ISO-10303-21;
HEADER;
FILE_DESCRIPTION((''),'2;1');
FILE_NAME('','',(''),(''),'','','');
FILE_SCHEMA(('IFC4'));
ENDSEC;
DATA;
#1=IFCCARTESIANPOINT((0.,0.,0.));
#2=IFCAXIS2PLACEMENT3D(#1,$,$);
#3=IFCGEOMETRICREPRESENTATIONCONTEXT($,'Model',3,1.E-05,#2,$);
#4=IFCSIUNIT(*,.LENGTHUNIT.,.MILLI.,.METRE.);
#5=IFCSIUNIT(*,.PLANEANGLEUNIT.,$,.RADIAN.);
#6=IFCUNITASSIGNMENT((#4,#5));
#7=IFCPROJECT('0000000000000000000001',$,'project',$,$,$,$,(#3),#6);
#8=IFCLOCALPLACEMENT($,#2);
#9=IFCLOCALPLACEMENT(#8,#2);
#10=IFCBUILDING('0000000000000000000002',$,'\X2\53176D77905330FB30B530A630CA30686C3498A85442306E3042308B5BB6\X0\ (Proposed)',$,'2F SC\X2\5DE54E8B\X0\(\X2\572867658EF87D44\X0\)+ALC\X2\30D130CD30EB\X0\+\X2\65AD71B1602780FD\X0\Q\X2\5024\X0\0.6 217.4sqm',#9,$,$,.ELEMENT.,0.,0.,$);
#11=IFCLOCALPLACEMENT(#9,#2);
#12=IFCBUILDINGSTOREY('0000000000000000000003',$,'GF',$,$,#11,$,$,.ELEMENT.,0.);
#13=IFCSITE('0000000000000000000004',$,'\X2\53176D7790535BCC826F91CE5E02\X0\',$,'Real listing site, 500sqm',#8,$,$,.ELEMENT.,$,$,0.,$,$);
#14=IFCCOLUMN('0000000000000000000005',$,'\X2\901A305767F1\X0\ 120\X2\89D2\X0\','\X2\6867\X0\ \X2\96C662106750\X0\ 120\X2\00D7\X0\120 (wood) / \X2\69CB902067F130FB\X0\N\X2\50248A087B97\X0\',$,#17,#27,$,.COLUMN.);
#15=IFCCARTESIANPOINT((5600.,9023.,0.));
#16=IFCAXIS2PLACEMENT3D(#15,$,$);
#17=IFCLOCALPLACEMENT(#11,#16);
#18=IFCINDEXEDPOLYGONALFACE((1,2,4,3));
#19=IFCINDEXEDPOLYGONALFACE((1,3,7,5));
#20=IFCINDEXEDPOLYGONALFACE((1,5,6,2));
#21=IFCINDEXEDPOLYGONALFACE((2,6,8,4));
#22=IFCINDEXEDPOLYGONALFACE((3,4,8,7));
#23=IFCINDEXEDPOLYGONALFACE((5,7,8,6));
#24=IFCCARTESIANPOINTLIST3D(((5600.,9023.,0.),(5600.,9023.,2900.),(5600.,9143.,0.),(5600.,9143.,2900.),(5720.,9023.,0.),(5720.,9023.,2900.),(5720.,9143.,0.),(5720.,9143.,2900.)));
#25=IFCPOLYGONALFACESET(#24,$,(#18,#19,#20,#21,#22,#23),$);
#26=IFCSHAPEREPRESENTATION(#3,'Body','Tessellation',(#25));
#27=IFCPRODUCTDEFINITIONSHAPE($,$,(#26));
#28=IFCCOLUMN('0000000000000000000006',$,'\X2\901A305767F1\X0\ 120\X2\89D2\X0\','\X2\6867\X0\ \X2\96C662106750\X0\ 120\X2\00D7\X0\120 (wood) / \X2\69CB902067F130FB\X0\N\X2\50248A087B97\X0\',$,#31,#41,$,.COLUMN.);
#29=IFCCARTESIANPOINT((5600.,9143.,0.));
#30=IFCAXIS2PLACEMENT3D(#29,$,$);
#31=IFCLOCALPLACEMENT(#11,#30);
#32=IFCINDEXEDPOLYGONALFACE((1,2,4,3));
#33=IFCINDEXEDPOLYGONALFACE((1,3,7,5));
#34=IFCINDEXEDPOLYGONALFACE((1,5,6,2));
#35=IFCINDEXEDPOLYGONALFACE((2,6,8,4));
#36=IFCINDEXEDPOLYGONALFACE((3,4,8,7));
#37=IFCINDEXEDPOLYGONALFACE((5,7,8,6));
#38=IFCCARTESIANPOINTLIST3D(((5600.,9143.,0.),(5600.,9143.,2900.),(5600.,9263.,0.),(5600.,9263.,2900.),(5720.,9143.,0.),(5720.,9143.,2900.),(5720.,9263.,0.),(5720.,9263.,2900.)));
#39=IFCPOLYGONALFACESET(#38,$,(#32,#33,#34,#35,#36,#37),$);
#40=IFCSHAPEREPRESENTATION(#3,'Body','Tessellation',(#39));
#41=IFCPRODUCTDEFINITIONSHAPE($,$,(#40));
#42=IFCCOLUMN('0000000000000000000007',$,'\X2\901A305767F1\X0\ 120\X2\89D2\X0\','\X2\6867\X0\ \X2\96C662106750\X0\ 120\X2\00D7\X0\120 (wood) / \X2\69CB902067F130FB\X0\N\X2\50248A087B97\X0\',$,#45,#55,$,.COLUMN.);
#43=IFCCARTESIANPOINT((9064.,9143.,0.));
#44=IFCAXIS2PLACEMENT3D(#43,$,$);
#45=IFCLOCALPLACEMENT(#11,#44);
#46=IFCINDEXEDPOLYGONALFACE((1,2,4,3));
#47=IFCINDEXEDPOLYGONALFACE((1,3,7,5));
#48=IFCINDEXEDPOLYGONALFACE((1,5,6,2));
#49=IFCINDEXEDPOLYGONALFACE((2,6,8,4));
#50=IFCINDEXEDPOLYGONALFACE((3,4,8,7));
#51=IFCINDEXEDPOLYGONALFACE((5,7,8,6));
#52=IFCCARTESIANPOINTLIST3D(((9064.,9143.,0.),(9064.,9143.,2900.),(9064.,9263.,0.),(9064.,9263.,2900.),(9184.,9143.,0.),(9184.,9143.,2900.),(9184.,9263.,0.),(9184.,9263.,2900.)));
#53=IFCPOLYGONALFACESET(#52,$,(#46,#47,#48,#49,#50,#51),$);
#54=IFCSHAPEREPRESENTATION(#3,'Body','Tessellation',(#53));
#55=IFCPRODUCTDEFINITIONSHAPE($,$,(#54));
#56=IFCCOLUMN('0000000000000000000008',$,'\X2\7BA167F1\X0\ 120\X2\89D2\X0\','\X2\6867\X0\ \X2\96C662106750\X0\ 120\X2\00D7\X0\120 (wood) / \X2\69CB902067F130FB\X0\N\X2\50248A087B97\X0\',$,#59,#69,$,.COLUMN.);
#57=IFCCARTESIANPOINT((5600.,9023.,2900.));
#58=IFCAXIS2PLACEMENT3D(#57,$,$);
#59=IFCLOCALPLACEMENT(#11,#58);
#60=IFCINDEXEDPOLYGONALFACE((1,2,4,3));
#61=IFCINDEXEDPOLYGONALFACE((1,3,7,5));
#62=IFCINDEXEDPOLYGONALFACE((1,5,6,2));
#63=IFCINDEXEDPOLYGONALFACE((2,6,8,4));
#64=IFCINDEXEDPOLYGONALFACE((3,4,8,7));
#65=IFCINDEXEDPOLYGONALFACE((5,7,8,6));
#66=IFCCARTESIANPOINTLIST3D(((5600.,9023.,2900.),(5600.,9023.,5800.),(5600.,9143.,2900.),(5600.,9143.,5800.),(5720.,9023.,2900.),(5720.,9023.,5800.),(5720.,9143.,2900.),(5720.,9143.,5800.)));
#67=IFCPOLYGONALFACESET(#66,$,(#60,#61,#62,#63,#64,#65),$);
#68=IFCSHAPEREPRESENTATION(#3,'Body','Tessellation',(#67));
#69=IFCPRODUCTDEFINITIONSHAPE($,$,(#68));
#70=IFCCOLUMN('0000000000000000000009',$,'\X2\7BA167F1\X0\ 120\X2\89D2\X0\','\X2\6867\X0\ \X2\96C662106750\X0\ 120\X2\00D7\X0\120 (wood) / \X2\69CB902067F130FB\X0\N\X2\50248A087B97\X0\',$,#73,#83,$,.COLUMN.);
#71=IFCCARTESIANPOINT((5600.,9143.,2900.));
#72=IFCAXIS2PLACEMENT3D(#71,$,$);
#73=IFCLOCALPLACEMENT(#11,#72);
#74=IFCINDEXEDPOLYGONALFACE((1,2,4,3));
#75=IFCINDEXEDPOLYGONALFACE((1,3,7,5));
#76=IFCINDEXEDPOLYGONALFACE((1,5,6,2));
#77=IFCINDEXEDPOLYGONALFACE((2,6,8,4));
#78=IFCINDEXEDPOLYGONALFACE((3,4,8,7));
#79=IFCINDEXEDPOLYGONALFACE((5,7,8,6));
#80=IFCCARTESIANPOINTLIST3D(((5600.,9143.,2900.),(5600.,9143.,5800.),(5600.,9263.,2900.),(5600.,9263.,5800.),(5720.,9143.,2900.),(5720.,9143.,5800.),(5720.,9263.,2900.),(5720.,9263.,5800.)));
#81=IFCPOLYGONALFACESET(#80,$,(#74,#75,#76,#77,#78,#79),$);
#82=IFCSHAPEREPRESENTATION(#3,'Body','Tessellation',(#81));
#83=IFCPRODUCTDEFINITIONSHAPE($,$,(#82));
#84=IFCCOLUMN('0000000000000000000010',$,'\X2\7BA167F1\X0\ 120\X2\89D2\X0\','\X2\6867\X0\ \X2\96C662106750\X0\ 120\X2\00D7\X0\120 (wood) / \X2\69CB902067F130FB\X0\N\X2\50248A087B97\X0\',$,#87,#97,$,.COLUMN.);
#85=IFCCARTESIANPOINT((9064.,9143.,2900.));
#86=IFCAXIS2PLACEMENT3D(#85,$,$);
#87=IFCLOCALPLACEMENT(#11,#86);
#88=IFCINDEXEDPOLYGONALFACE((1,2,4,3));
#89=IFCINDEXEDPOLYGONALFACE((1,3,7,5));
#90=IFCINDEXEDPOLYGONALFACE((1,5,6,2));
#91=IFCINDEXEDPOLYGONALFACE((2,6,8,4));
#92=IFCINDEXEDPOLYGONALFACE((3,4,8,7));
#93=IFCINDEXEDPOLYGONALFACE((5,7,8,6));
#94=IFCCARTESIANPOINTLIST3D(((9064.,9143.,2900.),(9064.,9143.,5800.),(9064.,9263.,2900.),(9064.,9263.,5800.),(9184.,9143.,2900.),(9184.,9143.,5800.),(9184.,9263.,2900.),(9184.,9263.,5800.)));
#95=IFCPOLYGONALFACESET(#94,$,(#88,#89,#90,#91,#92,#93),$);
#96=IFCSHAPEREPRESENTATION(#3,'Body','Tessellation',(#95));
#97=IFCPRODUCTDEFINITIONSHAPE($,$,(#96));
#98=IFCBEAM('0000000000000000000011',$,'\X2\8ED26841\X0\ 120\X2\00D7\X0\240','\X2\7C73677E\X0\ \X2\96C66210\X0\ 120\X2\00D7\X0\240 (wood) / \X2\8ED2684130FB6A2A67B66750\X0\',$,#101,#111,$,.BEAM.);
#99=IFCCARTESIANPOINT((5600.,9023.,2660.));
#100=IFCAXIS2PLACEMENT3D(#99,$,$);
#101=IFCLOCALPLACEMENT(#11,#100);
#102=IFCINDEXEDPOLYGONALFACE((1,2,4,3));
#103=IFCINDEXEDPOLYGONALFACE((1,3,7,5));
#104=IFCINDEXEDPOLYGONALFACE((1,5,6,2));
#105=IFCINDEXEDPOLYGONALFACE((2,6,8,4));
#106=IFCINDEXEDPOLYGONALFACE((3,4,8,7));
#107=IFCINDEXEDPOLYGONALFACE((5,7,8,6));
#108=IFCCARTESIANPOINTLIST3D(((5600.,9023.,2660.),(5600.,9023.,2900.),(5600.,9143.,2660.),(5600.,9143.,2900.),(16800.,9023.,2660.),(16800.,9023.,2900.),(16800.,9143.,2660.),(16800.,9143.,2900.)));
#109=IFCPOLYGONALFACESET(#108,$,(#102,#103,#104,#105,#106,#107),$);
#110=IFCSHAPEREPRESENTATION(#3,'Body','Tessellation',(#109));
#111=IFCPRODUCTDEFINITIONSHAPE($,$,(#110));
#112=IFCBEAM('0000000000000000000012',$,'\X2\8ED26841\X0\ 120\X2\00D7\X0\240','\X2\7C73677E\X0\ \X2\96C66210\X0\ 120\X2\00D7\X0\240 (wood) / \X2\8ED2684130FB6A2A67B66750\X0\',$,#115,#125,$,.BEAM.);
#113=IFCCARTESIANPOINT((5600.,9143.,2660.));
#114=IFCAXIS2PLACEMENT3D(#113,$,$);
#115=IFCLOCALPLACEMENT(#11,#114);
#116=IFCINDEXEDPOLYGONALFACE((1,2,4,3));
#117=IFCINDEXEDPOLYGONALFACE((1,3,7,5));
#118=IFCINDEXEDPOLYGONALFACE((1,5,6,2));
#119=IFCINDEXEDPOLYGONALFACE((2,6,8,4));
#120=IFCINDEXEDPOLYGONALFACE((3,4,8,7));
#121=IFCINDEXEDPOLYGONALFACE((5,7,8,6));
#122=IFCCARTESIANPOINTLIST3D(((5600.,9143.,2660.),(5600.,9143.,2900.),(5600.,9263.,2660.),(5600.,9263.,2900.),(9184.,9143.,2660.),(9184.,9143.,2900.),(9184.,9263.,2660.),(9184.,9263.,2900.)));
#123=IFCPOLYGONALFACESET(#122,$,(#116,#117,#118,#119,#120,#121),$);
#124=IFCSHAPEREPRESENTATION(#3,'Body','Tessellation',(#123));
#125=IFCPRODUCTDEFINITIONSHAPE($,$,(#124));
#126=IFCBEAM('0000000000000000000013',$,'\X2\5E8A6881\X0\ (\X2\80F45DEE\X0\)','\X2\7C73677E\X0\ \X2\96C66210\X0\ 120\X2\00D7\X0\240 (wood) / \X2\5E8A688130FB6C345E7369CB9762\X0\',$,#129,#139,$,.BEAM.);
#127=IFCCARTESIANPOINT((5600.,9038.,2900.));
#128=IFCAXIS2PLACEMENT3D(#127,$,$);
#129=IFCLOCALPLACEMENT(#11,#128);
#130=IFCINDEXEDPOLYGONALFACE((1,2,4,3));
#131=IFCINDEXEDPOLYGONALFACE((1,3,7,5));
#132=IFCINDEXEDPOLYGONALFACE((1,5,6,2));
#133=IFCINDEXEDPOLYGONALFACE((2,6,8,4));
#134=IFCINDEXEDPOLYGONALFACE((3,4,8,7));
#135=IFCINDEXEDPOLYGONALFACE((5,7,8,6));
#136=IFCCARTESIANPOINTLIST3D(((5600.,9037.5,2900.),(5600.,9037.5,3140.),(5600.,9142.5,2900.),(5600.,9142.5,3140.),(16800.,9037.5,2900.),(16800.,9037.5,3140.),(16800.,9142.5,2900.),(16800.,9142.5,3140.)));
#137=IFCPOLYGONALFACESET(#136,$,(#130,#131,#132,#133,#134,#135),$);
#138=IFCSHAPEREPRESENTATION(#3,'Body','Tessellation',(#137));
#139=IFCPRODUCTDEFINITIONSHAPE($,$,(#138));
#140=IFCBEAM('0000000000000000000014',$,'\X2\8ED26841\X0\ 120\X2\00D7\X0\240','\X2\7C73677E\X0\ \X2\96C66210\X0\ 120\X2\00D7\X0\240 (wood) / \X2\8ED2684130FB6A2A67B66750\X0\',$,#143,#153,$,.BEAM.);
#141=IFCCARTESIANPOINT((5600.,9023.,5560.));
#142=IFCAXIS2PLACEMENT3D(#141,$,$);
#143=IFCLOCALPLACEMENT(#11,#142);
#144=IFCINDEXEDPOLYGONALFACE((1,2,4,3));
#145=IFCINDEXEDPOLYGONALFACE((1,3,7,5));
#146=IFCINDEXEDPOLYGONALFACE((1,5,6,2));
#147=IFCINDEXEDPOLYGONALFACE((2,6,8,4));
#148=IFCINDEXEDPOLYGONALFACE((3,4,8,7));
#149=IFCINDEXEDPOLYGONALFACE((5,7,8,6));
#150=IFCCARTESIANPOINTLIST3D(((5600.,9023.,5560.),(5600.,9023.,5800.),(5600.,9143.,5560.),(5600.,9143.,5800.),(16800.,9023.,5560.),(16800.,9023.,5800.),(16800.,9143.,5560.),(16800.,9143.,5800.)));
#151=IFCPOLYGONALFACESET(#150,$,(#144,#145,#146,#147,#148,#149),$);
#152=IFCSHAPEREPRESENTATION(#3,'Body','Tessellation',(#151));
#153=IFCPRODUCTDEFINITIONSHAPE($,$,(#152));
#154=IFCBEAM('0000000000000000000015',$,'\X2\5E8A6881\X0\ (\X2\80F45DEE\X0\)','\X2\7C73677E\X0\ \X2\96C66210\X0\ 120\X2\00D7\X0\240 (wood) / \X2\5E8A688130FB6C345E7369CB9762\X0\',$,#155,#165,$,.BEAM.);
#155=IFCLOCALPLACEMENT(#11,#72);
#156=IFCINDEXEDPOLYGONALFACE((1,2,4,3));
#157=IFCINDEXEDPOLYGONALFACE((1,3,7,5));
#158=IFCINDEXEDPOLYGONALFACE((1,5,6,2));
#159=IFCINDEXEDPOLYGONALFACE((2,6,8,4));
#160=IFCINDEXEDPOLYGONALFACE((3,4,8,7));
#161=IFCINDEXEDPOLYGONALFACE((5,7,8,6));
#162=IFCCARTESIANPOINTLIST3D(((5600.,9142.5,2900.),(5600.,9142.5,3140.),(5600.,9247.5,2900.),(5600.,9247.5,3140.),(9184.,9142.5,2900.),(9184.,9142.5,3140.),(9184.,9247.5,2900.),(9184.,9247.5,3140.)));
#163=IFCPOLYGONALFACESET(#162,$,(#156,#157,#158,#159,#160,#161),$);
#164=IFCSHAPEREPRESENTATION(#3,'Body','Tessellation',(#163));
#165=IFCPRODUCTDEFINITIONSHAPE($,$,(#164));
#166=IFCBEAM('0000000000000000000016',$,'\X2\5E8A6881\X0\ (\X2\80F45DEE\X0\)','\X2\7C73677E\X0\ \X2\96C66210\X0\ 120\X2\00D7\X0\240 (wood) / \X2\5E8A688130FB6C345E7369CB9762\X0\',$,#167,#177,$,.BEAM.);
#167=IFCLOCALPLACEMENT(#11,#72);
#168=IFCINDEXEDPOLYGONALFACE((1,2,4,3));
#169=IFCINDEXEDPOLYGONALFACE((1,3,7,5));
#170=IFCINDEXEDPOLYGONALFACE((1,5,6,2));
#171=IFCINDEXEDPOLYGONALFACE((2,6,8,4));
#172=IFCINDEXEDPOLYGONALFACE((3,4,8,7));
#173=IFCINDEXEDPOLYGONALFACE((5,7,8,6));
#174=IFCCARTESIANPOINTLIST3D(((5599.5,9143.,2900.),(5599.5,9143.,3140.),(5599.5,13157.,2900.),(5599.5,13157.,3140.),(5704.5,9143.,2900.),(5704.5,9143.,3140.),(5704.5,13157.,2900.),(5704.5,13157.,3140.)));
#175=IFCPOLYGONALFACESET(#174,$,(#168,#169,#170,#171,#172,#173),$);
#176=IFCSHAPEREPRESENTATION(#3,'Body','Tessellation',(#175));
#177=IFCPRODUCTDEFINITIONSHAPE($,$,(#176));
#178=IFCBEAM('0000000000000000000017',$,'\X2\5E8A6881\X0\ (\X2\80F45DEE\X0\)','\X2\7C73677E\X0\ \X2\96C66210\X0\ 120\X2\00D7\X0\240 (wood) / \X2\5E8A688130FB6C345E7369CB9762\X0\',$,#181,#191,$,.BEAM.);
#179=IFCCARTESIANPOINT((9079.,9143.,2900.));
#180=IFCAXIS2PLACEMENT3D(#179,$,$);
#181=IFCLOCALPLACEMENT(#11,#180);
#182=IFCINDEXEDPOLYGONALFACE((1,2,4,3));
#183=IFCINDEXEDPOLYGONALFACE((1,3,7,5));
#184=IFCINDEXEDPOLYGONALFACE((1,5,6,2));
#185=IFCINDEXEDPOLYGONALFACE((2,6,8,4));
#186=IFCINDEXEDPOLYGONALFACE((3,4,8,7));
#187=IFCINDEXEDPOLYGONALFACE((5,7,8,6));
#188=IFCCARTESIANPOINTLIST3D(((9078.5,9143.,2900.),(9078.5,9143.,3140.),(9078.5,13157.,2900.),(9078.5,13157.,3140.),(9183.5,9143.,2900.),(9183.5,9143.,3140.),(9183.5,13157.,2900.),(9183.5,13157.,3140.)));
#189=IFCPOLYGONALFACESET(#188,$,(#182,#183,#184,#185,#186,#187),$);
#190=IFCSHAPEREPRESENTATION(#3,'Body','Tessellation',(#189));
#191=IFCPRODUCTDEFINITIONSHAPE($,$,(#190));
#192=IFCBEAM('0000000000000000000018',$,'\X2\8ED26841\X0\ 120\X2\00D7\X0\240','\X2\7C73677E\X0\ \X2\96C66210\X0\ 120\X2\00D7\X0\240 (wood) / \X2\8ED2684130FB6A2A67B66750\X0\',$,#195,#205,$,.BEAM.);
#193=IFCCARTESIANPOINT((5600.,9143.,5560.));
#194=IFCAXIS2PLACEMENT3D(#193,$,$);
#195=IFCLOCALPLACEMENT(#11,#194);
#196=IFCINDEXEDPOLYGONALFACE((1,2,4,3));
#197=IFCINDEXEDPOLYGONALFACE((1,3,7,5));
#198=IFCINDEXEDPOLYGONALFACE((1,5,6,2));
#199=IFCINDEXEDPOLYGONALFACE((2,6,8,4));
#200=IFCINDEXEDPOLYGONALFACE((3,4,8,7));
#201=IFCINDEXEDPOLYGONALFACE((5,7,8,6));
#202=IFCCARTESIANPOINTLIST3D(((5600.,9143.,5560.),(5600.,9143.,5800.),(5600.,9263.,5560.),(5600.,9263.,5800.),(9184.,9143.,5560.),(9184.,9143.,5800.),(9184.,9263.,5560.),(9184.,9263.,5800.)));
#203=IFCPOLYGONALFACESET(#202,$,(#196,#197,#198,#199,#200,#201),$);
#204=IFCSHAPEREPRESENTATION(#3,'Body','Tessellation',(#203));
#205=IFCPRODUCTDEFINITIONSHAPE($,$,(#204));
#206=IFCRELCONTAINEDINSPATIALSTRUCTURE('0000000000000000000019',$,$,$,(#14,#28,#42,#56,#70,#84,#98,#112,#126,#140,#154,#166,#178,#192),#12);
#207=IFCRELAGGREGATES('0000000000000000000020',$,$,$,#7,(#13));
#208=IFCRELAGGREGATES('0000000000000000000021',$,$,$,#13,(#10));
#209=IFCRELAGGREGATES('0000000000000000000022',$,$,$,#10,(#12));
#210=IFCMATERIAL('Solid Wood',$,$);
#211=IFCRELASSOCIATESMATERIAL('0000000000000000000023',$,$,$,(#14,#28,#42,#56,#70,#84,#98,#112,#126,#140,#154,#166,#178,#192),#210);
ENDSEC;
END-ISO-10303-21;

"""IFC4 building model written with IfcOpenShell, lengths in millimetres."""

from ifc_helpers import new_model, si_unit, frame, frame_2d, origin, place, context, project, spatial, rectangle, extrude, material, element, save


model = new_model("IFC4")

# Units and contexts
model_context = context("Model", 3, precision=1e-05, world=origin())
ifc_project = project(units=[si_unit("LENGTHUNIT", "METRE", prefix="MILLI"), si_unit("PLANEANGLEUNIT", "RADIAN")], contexts=[model_context])

# Site, building, storey
site_placement = place(None, origin())
site = spatial("IfcSite", under=ifc_project, at=site_placement, Name="北海道富良野市", ObjectType="Real listing site, 500sqm", CompositionType="ELEMENT", RefElevation=0.0)
building_placement = place(site_placement, origin())
building = spatial("IfcBuilding", under=site, at=building_placement, Name="北海道・サウナと水風呂のある家 (Proposed)", ObjectType="2F SC工事(在来軸組)+ALCパネル+断熱性能Q値0.6 217.4sqm", CompositionType="ELEMENT", ElevationOfRefHeight=0.0, ElevationOfTerrain=0.0)
storey_placement = place(building_placement, origin())
storey = spatial("IfcBuildingStorey", under=building, at=storey_placement, Name="GF", CompositionType="ELEMENT", Elevation=0.0)

# Columns
ifc_material_1 = material(Name="Solid Wood")
column_1_placement = place(storey_placement, frame((5600.0, 9023.0, 0.0)))
element("IfcColumn", 1, at=column_1_placement, inside=storey, material=ifc_material_1, Name="通し柱 120角", Description="桧 集成材 120×120 (wood) / 構造柱・N値計算", PredefinedType="COLUMN", context=model_context, shape_type="SweptSolid", body=[
    extrude(rectangle(XDim=120.0, YDim=120.0, at=frame_2d((60.0, 60.0))), frame((5600.0, 9023.0, 0.0)), (0.0, 0.0, 1.0), 2900.0),
])
column_2_placement = place(storey_placement, frame((5600.0, 9143.0, 0.0)))
element("IfcColumn", 2, at=column_2_placement, inside=storey, material=ifc_material_1, Name="通し柱 120角", Description="桧 集成材 120×120 (wood) / 構造柱・N値計算", PredefinedType="COLUMN", context=model_context, shape_type="SweptSolid", body=[
    extrude(rectangle(XDim=120.0, YDim=120.0, at=frame_2d((60.0, 60.0))), frame((5600.0, 9143.0, 0.0)), (0.0, 0.0, 1.0), 2900.0),
])
column_3_placement = place(storey_placement, frame((9064.0, 9143.0, 0.0)))
element("IfcColumn", 3, at=column_3_placement, inside=storey, material=ifc_material_1, Name="通し柱 120角", Description="桧 集成材 120×120 (wood) / 構造柱・N値計算", PredefinedType="COLUMN", context=model_context, shape_type="SweptSolid", body=[
    extrude(rectangle(XDim=120.0, YDim=120.0, at=frame_2d((60.0, 60.0))), frame((9064.0, 9143.0, 0.0)), (0.0, 0.0, 1.0), 2900.0),
])
column_4_placement = place(storey_placement, frame((5600.0, 9023.0, 2900.0)))
element("IfcColumn", 4, at=column_4_placement, inside=storey, material=ifc_material_1, Name="管柱 120角", Description="桧 集成材 120×120 (wood) / 構造柱・N値計算", PredefinedType="COLUMN", context=model_context, shape_type="SweptSolid", body=[
    extrude(rectangle(XDim=120.0, YDim=120.0, at=frame_2d((60.0, 60.0))), frame((5600.0, 9023.0, 2900.0)), (0.0, 0.0, 1.0), 2900.0),
])
column_5_placement = place(storey_placement, frame((5600.0, 9143.0, 2900.0)))
element("IfcColumn", 5, at=column_5_placement, inside=storey, material=ifc_material_1, Name="管柱 120角", Description="桧 集成材 120×120 (wood) / 構造柱・N値計算", PredefinedType="COLUMN", context=model_context, shape_type="SweptSolid", body=[
    extrude(rectangle(XDim=120.0, YDim=120.0, at=frame_2d((60.0, 60.0))), frame((5600.0, 9143.0, 2900.0)), (0.0, 0.0, 1.0), 2900.0),
])
column_6_placement = place(storey_placement, frame((9064.0, 9143.0, 2900.0)))
element("IfcColumn", 6, at=column_6_placement, inside=storey, material=ifc_material_1, Name="管柱 120角", Description="桧 集成材 120×120 (wood) / 構造柱・N値計算", PredefinedType="COLUMN", context=model_context, shape_type="SweptSolid", body=[
    extrude(rectangle(XDim=120.0, YDim=120.0, at=frame_2d((60.0, 60.0))), frame((9064.0, 9143.0, 2900.0)), (0.0, 0.0, 1.0), 2900.0),
])

# Beams
beam_1_placement = place(storey_placement, frame((5600.0, 9023.0, 2660.0)))
element("IfcBeam", 7, at=beam_1_placement, inside=storey, material=ifc_material_1, Name="軒桁 120×240", Description="米松 集成 120×240 (wood) / 軒桁・横架材", PredefinedType="BEAM", context=model_context, shape_type="SweptSolid", body=[
    extrude(rectangle(XDim=11200.0, YDim=120.0, at=frame_2d((5600.0, 60.0))), frame((5600.0, 9023.0, 2660.0)), (0.0, 0.0, 1.0), 240.0),
])
beam_2_placement = place(storey_placement, frame((5600.0, 9143.0, 2660.0)))
element("IfcBeam", 8, at=beam_2_placement, inside=storey, material=ifc_material_1, Name="軒桁 120×240", Description="米松 集成 120×240 (wood) / 軒桁・横架材", PredefinedType="BEAM", context=model_context, shape_type="SweptSolid", body=[
    extrude(rectangle(XDim=3584.0, YDim=120.0, at=frame_2d((1792.0, 60.0))), frame((5600.0, 9143.0, 2660.0)), (0.0, 0.0, 1.0), 240.0),
])
beam_3_placement = place(storey_placement, frame((5600.0, 9038.0, 2900.0)))
element("IfcBeam", 9, at=beam_3_placement, inside=storey, material=ifc_material_1, Name="床梁 (胴差)", Description="米松 集成 120×240 (wood) / 床梁・水平構面", PredefinedType="BEAM", context=model_context, shape_type="SweptSolid", body=[
    extrude(rectangle(XDim=11200.0, YDim=105.0, at=frame_2d((5600.0, 52.0))), frame((5600.0, 9038.0, 2900.0)), (0.0, 0.0, 1.0), 240.0),
])
beam_4_placement = place(storey_placement, frame((5600.0, 9023.0, 5560.0)))
element("IfcBeam", 10, at=beam_4_placement, inside=storey, material=ifc_material_1, Name="軒桁 120×240", Description="米松 集成 120×240 (wood) / 軒桁・横架材", PredefinedType="BEAM", context=model_context, shape_type="SweptSolid", body=[
    extrude(rectangle(XDim=11200.0, YDim=120.0, at=frame_2d((5600.0, 60.0))), frame((5600.0, 9023.0, 5560.0)), (0.0, 0.0, 1.0), 240.0),
])
beam_5_placement = place(storey_placement, frame((5600.0, 9143.0, 2900.0)))
element("IfcBeam", 11, at=beam_5_placement, inside=storey, material=ifc_material_1, Name="床梁 (胴差)", Description="米松 集成 120×240 (wood) / 床梁・水平構面", PredefinedType="BEAM", context=model_context, shape_type="SweptSolid", body=[
    extrude(rectangle(XDim=3584.0, YDim=105.0, at=frame_2d((1792.0, 52.0))), frame((5600.0, 9143.0, 2900.0)), (0.0, 0.0, 1.0), 240.0),
])
beam_6_placement = place(storey_placement, frame((5600.0, 9143.0, 2900.0)))
element("IfcBeam", 12, at=beam_6_placement, inside=storey, material=ifc_material_1, Name="床梁 (胴差)", Description="米松 集成 120×240 (wood) / 床梁・水平構面", PredefinedType="BEAM", context=model_context, shape_type="SweptSolid", body=[
    extrude(rectangle(XDim=105.0, YDim=4014.0, at=frame_2d((52.0, 2007.0))), frame((5600.0, 9143.0, 2900.0)), (0.0, 0.0, 1.0), 240.0),
])
beam_7_placement = place(storey_placement, frame((9079.0, 9143.0, 2900.0)))
element("IfcBeam", 13, at=beam_7_placement, inside=storey, material=ifc_material_1, Name="床梁 (胴差)", Description="米松 集成 120×240 (wood) / 床梁・水平構面", PredefinedType="BEAM", context=model_context, shape_type="SweptSolid", body=[
    extrude(rectangle(XDim=105.0, YDim=4014.0, at=frame_2d((52.0, 2007.0))), frame((9079.0, 9143.0, 2900.0)), (0.0, 0.0, 1.0), 240.0),
])
beam_8_placement = place(storey_placement, frame((5600.0, 9143.0, 5560.0)))
element("IfcBeam", 14, at=beam_8_placement, inside=storey, material=ifc_material_1, Name="軒桁 120×240", Description="米松 集成 120×240 (wood) / 軒桁・横架材", PredefinedType="BEAM", context=model_context, shape_type="SweptSolid", body=[
    extrude(rectangle(XDim=3584.0, YDim=120.0, at=frame_2d((1792.0, 60.0))), frame((5600.0, 9143.0, 5560.0)), (0.0, 0.0, 1.0), 240.0),
])

save(model, "model.ifc")
